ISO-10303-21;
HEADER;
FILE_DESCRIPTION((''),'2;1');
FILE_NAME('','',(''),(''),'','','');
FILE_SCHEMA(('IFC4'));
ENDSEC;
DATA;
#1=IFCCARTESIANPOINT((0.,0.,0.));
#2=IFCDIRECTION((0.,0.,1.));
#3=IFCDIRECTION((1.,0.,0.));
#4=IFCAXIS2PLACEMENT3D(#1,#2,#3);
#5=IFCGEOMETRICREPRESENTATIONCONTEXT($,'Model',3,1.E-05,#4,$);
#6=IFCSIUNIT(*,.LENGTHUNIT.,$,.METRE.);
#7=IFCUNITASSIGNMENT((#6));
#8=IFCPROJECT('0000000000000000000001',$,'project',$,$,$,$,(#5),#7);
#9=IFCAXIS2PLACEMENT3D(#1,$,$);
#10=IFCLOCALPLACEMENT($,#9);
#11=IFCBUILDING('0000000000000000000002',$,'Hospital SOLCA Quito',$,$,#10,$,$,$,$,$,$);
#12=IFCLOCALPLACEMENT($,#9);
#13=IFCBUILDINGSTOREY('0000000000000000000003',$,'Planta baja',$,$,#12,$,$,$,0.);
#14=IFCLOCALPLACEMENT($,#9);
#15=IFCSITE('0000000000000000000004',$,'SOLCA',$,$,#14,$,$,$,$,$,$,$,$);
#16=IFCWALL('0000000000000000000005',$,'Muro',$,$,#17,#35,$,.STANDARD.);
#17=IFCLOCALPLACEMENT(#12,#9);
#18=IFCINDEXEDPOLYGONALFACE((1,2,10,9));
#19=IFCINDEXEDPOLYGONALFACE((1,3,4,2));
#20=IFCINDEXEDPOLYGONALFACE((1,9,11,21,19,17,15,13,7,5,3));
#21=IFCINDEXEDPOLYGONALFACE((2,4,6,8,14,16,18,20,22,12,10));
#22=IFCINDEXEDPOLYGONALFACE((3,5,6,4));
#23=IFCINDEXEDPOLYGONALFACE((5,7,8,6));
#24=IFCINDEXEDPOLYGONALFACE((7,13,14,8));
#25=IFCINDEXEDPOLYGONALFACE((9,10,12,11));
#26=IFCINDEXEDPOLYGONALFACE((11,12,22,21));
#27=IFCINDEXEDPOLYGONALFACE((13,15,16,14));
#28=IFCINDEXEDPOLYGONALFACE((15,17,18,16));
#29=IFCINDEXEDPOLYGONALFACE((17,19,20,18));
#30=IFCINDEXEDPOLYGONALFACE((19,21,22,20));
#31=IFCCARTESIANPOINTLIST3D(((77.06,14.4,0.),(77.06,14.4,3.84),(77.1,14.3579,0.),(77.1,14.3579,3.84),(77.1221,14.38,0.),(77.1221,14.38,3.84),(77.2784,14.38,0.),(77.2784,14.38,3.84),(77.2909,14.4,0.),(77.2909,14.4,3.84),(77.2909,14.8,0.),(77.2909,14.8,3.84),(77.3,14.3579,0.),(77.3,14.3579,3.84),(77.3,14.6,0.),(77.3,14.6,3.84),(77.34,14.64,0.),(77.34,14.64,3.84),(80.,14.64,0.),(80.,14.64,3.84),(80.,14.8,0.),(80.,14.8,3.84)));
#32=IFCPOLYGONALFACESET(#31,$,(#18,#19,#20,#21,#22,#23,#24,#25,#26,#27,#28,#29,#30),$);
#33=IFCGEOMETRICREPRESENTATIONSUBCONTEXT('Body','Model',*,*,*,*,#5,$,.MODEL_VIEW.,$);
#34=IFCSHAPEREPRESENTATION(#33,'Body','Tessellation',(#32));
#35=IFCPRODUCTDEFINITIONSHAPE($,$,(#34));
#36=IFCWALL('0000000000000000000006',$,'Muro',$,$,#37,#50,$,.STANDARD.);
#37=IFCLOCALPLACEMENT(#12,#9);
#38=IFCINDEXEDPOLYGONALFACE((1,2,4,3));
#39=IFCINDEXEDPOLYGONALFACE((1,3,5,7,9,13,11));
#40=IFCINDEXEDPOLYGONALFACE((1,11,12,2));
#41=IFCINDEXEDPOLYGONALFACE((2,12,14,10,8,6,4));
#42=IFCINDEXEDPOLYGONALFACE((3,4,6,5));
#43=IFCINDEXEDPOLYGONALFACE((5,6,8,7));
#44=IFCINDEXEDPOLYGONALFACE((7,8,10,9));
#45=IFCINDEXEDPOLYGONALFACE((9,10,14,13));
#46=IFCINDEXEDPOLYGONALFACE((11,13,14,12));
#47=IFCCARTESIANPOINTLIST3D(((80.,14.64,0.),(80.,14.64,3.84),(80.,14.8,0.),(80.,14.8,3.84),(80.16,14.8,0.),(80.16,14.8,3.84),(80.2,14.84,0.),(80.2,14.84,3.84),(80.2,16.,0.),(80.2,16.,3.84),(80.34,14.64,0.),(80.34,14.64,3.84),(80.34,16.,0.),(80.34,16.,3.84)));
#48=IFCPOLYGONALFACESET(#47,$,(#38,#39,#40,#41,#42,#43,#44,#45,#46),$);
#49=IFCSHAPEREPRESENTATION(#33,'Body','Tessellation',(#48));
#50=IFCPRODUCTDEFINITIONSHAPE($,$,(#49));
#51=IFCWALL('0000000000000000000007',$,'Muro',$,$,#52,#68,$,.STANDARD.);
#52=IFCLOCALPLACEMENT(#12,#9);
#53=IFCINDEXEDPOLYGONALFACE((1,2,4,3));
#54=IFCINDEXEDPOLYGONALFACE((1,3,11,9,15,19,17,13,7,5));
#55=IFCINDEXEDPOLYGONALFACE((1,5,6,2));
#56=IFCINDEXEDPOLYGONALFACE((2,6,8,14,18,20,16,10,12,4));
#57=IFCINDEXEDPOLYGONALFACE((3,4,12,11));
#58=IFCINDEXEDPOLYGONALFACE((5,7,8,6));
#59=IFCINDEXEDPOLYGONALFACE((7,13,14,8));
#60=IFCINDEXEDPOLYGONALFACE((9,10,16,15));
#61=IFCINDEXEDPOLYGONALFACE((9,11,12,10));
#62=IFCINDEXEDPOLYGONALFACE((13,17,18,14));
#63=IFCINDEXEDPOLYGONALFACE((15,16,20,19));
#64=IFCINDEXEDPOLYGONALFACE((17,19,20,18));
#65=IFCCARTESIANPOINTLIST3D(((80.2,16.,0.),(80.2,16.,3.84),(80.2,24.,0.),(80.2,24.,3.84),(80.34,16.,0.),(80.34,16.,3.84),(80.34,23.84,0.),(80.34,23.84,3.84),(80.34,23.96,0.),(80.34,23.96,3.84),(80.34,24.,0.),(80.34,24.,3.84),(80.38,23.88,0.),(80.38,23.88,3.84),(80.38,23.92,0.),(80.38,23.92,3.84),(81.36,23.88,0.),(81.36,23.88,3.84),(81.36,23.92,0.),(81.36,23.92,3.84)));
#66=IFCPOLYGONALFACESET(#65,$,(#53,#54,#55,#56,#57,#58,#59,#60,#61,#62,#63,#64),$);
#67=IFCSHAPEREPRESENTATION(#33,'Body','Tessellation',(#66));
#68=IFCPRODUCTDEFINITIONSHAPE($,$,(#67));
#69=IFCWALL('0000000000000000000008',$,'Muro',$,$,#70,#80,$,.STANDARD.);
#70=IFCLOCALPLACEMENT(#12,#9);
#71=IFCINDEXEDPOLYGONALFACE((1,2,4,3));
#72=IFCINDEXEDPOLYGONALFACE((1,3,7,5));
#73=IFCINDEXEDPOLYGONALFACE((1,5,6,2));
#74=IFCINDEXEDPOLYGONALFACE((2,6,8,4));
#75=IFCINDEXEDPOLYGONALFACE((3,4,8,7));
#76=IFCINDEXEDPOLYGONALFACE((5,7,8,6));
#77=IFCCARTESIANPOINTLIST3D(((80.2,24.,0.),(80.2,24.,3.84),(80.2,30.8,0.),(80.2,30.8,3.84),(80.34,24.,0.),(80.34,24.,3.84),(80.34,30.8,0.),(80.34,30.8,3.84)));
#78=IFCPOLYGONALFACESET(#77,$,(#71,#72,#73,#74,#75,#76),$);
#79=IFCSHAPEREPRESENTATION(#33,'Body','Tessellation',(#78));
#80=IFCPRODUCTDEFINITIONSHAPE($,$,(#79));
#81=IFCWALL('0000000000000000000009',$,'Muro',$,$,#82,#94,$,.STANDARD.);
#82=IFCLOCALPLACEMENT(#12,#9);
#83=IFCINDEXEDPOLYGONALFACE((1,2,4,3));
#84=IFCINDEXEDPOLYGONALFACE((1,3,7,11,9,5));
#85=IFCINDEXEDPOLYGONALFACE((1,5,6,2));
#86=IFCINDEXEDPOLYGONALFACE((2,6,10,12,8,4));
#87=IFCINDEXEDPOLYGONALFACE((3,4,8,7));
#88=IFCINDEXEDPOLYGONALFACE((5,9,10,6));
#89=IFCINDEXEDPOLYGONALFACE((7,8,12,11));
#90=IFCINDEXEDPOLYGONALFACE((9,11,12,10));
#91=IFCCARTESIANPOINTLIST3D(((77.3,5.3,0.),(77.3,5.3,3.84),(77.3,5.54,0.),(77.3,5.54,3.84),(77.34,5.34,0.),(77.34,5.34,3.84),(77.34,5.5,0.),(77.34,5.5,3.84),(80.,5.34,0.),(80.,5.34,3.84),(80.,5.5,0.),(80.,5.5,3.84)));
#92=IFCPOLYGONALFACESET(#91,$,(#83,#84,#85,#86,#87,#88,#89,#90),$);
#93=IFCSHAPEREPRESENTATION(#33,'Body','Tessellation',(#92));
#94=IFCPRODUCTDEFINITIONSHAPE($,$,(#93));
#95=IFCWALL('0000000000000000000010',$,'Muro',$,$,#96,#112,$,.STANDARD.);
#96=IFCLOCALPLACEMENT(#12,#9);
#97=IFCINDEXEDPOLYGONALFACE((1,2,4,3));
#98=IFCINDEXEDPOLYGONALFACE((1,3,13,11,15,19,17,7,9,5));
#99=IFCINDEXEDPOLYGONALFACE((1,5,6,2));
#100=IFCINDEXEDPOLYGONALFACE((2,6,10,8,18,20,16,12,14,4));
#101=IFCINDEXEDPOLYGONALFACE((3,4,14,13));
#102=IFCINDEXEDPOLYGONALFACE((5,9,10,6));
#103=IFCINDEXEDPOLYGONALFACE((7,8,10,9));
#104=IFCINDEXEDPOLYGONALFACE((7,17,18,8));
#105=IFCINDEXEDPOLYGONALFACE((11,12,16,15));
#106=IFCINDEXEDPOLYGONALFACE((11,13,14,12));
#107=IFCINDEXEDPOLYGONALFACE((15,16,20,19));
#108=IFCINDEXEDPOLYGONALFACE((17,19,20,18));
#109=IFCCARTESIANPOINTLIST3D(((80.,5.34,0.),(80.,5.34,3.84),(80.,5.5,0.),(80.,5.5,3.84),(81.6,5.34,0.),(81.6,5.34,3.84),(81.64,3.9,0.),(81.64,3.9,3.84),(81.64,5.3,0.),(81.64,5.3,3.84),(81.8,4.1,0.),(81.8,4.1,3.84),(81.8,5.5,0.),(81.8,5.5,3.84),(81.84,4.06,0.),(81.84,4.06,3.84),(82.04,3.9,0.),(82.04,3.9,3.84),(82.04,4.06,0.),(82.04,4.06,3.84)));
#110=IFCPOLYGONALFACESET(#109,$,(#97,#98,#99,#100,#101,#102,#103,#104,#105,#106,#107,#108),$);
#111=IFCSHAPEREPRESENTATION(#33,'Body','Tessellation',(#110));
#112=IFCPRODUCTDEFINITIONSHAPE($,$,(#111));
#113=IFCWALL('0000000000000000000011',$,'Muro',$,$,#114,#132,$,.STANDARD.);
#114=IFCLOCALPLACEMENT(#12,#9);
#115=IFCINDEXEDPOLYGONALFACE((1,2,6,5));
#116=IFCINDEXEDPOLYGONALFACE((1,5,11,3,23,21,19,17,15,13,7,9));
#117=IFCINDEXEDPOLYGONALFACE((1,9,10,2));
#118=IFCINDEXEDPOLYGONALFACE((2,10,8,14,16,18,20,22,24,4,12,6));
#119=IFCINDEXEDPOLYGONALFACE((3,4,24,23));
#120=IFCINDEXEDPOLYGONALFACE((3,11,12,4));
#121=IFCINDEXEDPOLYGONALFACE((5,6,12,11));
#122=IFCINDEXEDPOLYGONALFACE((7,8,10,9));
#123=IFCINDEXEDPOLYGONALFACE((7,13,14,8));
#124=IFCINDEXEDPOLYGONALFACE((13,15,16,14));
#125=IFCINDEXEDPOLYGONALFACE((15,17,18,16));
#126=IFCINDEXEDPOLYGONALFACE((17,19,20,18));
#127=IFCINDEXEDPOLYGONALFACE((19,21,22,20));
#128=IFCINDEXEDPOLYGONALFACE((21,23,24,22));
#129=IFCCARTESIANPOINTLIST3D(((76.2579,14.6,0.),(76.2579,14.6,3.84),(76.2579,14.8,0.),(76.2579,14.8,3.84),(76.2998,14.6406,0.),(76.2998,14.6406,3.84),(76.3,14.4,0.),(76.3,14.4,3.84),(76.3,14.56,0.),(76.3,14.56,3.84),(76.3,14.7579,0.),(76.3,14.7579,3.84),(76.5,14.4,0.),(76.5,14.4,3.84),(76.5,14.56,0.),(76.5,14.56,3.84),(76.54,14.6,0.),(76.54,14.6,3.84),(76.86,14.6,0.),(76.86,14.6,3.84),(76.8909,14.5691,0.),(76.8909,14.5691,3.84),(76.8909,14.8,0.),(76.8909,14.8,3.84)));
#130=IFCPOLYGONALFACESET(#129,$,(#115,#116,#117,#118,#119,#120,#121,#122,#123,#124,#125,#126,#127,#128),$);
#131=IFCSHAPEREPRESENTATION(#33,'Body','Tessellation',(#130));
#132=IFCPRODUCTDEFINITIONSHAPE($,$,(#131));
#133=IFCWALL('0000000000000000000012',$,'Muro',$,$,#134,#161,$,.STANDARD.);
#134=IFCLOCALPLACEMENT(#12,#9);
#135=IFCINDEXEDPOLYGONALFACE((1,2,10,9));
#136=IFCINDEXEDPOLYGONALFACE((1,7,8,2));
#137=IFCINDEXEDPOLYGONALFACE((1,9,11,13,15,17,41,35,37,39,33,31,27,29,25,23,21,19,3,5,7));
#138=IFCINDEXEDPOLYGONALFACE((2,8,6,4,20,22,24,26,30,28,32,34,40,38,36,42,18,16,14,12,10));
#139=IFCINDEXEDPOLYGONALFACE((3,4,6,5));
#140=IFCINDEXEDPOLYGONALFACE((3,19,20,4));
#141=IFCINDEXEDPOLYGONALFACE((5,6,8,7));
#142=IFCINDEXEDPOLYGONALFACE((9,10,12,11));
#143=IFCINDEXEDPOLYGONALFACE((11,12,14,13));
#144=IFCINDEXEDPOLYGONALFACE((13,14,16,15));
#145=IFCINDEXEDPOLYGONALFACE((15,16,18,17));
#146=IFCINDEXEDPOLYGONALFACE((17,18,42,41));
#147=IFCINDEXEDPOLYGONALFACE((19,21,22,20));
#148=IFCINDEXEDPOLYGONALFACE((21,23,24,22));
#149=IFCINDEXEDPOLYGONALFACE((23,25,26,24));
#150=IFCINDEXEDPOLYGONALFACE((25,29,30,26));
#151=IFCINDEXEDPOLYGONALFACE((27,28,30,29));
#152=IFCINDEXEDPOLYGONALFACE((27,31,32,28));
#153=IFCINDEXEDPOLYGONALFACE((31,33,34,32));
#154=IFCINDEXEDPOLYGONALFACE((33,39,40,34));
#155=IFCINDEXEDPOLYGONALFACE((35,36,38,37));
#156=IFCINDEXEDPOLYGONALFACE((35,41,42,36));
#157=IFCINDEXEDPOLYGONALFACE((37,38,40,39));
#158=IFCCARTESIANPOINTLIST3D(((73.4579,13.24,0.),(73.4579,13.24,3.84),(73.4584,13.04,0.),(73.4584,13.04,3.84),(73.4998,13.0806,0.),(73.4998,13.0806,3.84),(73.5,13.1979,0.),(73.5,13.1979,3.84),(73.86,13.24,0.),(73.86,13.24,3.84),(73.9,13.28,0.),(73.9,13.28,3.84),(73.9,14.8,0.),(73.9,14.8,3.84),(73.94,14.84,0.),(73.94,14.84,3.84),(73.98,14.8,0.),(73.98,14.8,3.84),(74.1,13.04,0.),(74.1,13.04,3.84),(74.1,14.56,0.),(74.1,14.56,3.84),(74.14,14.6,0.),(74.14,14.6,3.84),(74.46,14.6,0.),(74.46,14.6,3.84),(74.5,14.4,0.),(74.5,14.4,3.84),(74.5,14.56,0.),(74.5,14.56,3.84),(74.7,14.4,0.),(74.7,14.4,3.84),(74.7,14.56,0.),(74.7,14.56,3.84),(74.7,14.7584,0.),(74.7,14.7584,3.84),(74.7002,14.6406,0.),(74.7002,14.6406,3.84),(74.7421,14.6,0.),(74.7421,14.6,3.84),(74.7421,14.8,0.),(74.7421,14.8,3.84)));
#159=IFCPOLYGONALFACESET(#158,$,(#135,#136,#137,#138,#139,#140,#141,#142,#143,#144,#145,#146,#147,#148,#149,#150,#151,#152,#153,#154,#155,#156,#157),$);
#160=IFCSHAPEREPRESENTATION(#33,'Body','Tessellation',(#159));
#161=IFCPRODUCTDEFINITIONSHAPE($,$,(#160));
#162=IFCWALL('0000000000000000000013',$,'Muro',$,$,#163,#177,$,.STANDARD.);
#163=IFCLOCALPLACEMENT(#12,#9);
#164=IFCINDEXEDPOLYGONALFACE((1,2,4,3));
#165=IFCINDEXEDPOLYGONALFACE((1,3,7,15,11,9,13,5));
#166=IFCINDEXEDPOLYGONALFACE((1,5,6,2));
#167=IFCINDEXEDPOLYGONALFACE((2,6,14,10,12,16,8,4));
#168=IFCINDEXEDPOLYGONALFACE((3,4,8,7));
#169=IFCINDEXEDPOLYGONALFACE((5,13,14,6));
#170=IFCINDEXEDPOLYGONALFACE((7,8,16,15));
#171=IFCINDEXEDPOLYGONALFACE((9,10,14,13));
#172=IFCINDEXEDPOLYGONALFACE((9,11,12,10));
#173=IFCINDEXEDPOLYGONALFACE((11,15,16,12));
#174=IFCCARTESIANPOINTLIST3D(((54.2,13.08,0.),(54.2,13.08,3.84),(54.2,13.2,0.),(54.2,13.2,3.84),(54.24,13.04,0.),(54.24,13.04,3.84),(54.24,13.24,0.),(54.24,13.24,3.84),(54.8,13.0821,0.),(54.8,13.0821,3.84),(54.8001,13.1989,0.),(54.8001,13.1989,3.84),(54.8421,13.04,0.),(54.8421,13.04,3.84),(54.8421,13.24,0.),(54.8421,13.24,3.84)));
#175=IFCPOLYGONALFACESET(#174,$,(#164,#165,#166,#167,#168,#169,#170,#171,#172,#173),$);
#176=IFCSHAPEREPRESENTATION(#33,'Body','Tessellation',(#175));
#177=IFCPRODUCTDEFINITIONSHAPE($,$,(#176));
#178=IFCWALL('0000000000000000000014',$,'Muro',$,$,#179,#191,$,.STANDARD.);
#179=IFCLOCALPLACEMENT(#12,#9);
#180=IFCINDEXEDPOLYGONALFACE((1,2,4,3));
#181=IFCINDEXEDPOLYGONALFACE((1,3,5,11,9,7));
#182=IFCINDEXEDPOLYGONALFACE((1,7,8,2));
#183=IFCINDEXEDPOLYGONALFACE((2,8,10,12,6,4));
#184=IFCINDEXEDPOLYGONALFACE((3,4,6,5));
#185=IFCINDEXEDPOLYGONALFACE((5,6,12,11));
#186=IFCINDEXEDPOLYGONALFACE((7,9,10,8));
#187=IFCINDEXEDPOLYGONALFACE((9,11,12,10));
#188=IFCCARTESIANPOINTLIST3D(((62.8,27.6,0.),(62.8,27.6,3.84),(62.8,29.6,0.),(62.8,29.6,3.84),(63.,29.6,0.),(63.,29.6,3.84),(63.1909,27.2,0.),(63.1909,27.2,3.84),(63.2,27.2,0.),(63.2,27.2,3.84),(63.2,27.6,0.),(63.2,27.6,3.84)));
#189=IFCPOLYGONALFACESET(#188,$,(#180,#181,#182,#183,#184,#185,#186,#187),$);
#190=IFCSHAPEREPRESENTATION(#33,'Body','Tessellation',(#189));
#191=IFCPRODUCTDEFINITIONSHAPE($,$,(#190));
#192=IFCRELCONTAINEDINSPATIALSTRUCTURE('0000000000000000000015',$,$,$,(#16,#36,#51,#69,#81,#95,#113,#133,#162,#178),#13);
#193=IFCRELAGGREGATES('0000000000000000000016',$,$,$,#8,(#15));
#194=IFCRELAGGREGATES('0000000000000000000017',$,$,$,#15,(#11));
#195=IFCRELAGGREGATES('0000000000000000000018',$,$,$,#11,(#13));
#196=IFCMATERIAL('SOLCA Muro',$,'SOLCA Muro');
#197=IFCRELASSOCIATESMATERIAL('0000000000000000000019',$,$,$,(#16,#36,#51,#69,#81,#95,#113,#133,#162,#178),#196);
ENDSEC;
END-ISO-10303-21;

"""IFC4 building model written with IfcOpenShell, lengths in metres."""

from ifc_helpers import new_model, si_unit, origin, origin_with_axes, place, context, subcontext, project, spatial, polyline, outline, extrude, material, element, save


model = new_model("IFC4")

# Units and contexts
model_context = context("Model", 3, precision=1e-05, world=origin_with_axes())
body_context = subcontext(model_context, "Body", "Model", "MODEL_VIEW")
ifc_project = project(units=[si_unit("LENGTHUNIT", "METRE")], contexts=[model_context])

# Site, building, storey
site_placement = place(None, origin())
site = spatial("IfcSite", under=ifc_project, at=site_placement, Name="SOLCA")
building_placement = place(None, origin())
building = spatial("IfcBuilding", under=site, at=building_placement, Name="Hospital SOLCA Quito")
storey_placement = place(None, origin())
storey = spatial("IfcBuildingStorey", under=building, at=storey_placement, Name="Planta baja", Elevation=0.0)

# Walls
ifc_material = material(Name="SOLCA Muro", Category="SOLCA Muro")
wall_1_placement = place(storey_placement, origin_with_axes())
element("IfcWall", 1, at=wall_1_placement, inside=storey, material=ifc_material, Name="Muro", PredefinedType="STANDARD", context=body_context, shape_type="SweptSolid", body=[
    extrude(outline(polyline([(77.3, 14.3579), (77.2784, 14.38), (77.1221, 14.38), (77.1, 14.3579), (77.06, 14.4), (77.2909, 14.4), (77.2909, 14.8), (80.0, 14.8), (80.0, 14.64), (77.34, 14.64), (77.3, 14.6), (77.3, 14.3579)])), origin_with_axes(), (0.0, 0.0, 1.0), 3.84),
])
wall_2_placement = place(storey_placement, origin_with_axes())
element("IfcWall", 2, at=wall_2_placement, inside=storey, material=ifc_material, Name="Muro", PredefinedType="STANDARD", context=body_context, shape_type="SweptSolid", body=[
    extrude(outline(polyline([(80.16, 14.8), (80.2, 14.84), (80.2, 16.0), (80.34, 16.0), (80.34, 14.64), (80.0, 14.64), (80.0, 14.8), (80.16, 14.8)])), origin_with_axes(), (0.0, 0.0, 1.0), 3.84),
])
wall_3_placement = place(storey_placement, origin_with_axes())
element("IfcWall", 3, at=wall_3_placement, inside=storey, material=ifc_material, Name="Muro", PredefinedType="STANDARD", context=body_context, shape_type="SweptSolid", body=[
    extrude(outline(polyline([(80.2, 24.0), (80.34, 24.0), (80.34, 23.96), (80.38, 23.92), (81.36, 23.92), (81.36, 23.88), (80.38, 23.88), (80.34, 23.84), (80.34, 16.0), (80.2, 16.0), (80.2, 24.0)])), origin_with_axes(), (0.0, 0.0, 1.0), 3.84),
])
wall_4_placement = place(storey_placement, origin_with_axes())
element("IfcWall", 4, at=wall_4_placement, inside=storey, material=ifc_material, Name="Muro", PredefinedType="STANDARD", context=body_context, shape_type="SweptSolid", body=[
    extrude(outline(polyline([(80.2, 30.8), (80.34, 30.8), (80.34, 24.0), (80.2, 24.0), (80.2, 30.8)])), origin_with_axes(), (0.0, 0.0, 1.0), 3.84),
])
wall_5_placement = place(storey_placement, origin_with_axes())
element("IfcWall", 5, at=wall_5_placement, inside=storey, material=ifc_material, Name="Muro", PredefinedType="STANDARD", context=body_context, shape_type="SweptSolid", body=[
    extrude(outline(polyline([(77.3, 5.3), (77.3, 5.54), (77.34, 5.5), (80.0, 5.5), (80.0, 5.34), (77.34, 5.34), (77.3, 5.3)])), origin_with_axes(), (0.0, 0.0, 1.0), 3.84),
])
wall_6_placement = place(storey_placement, origin_with_axes())
element("IfcWall", 6, at=wall_6_placement, inside=storey, material=ifc_material, Name="Muro", PredefinedType="STANDARD", context=body_context, shape_type="SweptSolid", body=[
    extrude(outline(polyline([(81.8, 5.5), (81.8, 4.1), (81.84, 4.06), (82.04, 4.06), (82.04, 3.9), (81.64, 3.9), (81.64, 5.3), (81.6, 5.34), (80.0, 5.34), (80.0, 5.5), (81.8, 5.5)])), origin_with_axes(), (0.0, 0.0, 1.0), 3.84),
])
wall_7_placement = place(storey_placement, origin_with_axes())
element("IfcWall", 7, at=wall_7_placement, inside=storey, material=ifc_material, Name="Muro", PredefinedType="STANDARD", context=body_context, shape_type="SweptSolid", body=[
    extrude(outline(polyline([(76.2579, 14.6), (76.2998, 14.6406), (76.3, 14.7579), (76.2579, 14.8), (76.8909, 14.8), (76.8909, 14.5691), (76.86, 14.6), (76.54, 14.6), (76.5, 14.56), (76.5, 14.4), (76.3, 14.4), (76.3, 14.56), (76.2579, 14.6)])), origin_with_axes(), (0.0, 0.0, 1.0), 3.84),
])
wall_8_placement = place(storey_placement, origin_with_axes())
element("IfcWall", 8, at=wall_8_placement, inside=storey, material=ifc_material, Name="Muro", PredefinedType="STANDARD", context=body_context, shape_type="SweptSolid", body=[
    extrude(outline(polyline([(73.4584, 13.04), (73.4998, 13.0806), (73.5, 13.1979), (73.4579, 13.24), (73.86, 13.24), (73.9, 13.28), (73.9, 14.8), (73.94, 14.84), (73.98, 14.8), (74.7421, 14.8), (74.7, 14.7584), (74.7002, 14.6406), (74.7421, 14.6), (74.7, 14.56), (74.7, 14.4), (74.5, 14.4), (74.5, 14.56), (74.46, 14.6), (74.14, 14.6), (74.1, 14.56), (74.1, 13.04), (73.4584, 13.04)])), origin_with_axes(), (0.0, 0.0, 1.0), 3.84),
])
wall_9_placement = place(storey_placement, origin_with_axes())
element("IfcWall", 9, at=wall_9_placement, inside=storey, material=ifc_material, Name="Muro", PredefinedType="STANDARD", context=body_context, shape_type="SweptSolid", body=[
    extrude(outline(polyline([(54.8421, 13.24), (54.8001, 13.1989), (54.8, 13.0821), (54.8421, 13.04), (54.24, 13.04), (54.2, 13.08), (54.2, 13.2), (54.24, 13.24), (54.8421, 13.24)])), origin_with_axes(), (0.0, 0.0, 1.0), 3.84),
])
wall_10_placement = place(storey_placement, origin_with_axes())
element("IfcWall", 10, at=wall_10_placement, inside=storey, material=ifc_material, Name="Muro", PredefinedType="STANDARD", context=body_context, shape_type="SweptSolid", body=[
    extrude(outline(polyline([(63.1909, 27.2), (62.8, 27.6), (62.8, 29.6), (63.0, 29.6), (63.2, 27.6), (63.2, 27.2), (63.1909, 27.2)])), origin_with_axes(), (0.0, 0.0, 1.0), 3.84),
])

save(model, "model.ifc")
